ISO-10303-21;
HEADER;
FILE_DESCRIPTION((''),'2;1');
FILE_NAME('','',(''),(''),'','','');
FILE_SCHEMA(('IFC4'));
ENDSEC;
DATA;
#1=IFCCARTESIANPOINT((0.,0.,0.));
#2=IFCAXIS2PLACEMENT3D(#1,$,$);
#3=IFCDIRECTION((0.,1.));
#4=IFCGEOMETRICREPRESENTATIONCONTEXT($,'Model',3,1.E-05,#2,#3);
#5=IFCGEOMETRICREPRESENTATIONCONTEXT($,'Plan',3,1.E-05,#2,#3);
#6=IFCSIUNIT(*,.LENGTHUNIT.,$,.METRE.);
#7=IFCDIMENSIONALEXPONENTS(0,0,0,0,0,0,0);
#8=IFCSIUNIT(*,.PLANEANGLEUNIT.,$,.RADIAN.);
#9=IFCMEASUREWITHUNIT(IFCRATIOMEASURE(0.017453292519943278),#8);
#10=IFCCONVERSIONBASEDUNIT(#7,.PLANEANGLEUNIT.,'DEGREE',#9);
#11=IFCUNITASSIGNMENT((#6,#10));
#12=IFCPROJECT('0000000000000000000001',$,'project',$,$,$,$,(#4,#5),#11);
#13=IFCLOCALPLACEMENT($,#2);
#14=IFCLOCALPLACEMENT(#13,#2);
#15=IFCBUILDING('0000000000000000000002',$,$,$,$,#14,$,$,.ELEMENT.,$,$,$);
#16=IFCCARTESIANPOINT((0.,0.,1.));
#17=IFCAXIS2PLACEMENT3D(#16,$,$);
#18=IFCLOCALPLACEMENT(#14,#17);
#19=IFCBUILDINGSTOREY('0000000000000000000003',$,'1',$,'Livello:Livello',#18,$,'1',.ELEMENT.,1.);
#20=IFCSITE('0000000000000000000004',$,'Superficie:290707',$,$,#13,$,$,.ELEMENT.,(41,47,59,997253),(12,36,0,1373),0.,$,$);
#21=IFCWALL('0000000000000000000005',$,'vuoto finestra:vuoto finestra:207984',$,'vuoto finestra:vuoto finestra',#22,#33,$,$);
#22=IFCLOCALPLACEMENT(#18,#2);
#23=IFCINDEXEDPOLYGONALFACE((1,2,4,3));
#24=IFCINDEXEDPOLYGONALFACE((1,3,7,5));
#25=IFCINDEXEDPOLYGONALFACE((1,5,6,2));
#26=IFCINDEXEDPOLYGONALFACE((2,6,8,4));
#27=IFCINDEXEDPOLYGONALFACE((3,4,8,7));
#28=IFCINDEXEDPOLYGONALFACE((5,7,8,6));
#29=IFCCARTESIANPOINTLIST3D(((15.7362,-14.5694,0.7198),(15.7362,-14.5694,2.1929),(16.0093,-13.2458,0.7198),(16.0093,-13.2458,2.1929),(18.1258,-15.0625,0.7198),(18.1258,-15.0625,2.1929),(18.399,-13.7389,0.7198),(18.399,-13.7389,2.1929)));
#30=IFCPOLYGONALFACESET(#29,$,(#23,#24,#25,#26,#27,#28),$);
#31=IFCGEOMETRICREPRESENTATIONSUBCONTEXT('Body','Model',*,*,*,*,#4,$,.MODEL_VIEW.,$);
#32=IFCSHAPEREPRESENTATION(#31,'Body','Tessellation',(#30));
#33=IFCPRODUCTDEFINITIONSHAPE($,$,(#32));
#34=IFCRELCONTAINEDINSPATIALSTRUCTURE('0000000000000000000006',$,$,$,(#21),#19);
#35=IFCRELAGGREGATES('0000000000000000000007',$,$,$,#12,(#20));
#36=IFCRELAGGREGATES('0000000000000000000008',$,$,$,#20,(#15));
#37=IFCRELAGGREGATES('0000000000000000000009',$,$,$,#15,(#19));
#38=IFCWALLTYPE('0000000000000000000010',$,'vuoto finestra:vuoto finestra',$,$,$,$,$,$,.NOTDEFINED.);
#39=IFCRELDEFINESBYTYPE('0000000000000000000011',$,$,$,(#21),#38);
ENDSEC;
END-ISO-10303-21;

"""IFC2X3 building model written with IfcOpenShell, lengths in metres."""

from ifc_helpers import new_model, entity, si_unit, converted_unit, direction, frame, frame_2d, origin, place, context, subcontext, project, spatial, rectangle, extrude, type_object, element, save


model = new_model("IFC2X3")

# Units and contexts
model_context = context("Model", 3, precision=1e-05, world=origin(), true_north=direction((0.0, 1.0)))
plan_context = context("Plan", 3, precision=1e-05, world=origin(), true_north=direction((0.0, 1.0)))
body_context = subcontext(model_context, "Body", "Model", "MODEL_VIEW")
ifc_project = project(units=[si_unit("LENGTHUNIT", "METRE"), converted_unit("PLANEANGLEUNIT", "DEGREE", entity("IfcRatioMeasure", 0.017453292519943278), si_unit("PLANEANGLEUNIT", "RADIAN"), dimensions=[0, 0, 0, 0, 0, 0, 0])], contexts=[model_context, plan_context])

# Site, building, storey
site_placement = place(None, origin())
site = spatial("IfcSite", under=ifc_project, at=site_placement, Name="Superficie:290707", CompositionType="ELEMENT", RefLatitude=(41, 47, 59, 997253), RefLongitude=(12, 36, 0, 1373), RefElevation=0.0)
building_placement = place(site_placement, origin())
building = spatial("IfcBuilding", under=site, at=building_placement, CompositionType="ELEMENT")
storey_placement = place(building_placement, frame((0.0, 0.0, 1.0)))
storey = spatial("IfcBuildingStorey", under=building, at=storey_placement, Name="1", ObjectType="Livello:Livello", LongName="1", CompositionType="ELEMENT", Elevation=1.0)

# Wall
wall_type = type_object("IfcWallType", Name="vuoto finestra:vuoto finestra", PredefinedType="NOTDEFINED")
wall_placement = place(storey_placement, frame((15.7362, -15.0625, 0.7198)))
element("IfcWall", 1, at=wall_placement, inside=storey, type_object=wall_type, Name="vuoto finestra:vuoto finestra:207984", ObjectType="vuoto finestra:vuoto finestra", context=body_context, shape_type="SweptSolid", body=[
    extrude(rectangle(XDim=2.44, YDim=1.3515, at=frame_2d((0.0, 0.0), x_axis=(1.0, 0.0))), frame((1.3314, 0.9084, 0.0), z_axis=(0.0, 0.0, 1.0), x_axis=(0.979362, -0.202112, 0.0)), (0.0, 0.0, 1.0), 1.4731),
])

save(model, "model.ifc")
